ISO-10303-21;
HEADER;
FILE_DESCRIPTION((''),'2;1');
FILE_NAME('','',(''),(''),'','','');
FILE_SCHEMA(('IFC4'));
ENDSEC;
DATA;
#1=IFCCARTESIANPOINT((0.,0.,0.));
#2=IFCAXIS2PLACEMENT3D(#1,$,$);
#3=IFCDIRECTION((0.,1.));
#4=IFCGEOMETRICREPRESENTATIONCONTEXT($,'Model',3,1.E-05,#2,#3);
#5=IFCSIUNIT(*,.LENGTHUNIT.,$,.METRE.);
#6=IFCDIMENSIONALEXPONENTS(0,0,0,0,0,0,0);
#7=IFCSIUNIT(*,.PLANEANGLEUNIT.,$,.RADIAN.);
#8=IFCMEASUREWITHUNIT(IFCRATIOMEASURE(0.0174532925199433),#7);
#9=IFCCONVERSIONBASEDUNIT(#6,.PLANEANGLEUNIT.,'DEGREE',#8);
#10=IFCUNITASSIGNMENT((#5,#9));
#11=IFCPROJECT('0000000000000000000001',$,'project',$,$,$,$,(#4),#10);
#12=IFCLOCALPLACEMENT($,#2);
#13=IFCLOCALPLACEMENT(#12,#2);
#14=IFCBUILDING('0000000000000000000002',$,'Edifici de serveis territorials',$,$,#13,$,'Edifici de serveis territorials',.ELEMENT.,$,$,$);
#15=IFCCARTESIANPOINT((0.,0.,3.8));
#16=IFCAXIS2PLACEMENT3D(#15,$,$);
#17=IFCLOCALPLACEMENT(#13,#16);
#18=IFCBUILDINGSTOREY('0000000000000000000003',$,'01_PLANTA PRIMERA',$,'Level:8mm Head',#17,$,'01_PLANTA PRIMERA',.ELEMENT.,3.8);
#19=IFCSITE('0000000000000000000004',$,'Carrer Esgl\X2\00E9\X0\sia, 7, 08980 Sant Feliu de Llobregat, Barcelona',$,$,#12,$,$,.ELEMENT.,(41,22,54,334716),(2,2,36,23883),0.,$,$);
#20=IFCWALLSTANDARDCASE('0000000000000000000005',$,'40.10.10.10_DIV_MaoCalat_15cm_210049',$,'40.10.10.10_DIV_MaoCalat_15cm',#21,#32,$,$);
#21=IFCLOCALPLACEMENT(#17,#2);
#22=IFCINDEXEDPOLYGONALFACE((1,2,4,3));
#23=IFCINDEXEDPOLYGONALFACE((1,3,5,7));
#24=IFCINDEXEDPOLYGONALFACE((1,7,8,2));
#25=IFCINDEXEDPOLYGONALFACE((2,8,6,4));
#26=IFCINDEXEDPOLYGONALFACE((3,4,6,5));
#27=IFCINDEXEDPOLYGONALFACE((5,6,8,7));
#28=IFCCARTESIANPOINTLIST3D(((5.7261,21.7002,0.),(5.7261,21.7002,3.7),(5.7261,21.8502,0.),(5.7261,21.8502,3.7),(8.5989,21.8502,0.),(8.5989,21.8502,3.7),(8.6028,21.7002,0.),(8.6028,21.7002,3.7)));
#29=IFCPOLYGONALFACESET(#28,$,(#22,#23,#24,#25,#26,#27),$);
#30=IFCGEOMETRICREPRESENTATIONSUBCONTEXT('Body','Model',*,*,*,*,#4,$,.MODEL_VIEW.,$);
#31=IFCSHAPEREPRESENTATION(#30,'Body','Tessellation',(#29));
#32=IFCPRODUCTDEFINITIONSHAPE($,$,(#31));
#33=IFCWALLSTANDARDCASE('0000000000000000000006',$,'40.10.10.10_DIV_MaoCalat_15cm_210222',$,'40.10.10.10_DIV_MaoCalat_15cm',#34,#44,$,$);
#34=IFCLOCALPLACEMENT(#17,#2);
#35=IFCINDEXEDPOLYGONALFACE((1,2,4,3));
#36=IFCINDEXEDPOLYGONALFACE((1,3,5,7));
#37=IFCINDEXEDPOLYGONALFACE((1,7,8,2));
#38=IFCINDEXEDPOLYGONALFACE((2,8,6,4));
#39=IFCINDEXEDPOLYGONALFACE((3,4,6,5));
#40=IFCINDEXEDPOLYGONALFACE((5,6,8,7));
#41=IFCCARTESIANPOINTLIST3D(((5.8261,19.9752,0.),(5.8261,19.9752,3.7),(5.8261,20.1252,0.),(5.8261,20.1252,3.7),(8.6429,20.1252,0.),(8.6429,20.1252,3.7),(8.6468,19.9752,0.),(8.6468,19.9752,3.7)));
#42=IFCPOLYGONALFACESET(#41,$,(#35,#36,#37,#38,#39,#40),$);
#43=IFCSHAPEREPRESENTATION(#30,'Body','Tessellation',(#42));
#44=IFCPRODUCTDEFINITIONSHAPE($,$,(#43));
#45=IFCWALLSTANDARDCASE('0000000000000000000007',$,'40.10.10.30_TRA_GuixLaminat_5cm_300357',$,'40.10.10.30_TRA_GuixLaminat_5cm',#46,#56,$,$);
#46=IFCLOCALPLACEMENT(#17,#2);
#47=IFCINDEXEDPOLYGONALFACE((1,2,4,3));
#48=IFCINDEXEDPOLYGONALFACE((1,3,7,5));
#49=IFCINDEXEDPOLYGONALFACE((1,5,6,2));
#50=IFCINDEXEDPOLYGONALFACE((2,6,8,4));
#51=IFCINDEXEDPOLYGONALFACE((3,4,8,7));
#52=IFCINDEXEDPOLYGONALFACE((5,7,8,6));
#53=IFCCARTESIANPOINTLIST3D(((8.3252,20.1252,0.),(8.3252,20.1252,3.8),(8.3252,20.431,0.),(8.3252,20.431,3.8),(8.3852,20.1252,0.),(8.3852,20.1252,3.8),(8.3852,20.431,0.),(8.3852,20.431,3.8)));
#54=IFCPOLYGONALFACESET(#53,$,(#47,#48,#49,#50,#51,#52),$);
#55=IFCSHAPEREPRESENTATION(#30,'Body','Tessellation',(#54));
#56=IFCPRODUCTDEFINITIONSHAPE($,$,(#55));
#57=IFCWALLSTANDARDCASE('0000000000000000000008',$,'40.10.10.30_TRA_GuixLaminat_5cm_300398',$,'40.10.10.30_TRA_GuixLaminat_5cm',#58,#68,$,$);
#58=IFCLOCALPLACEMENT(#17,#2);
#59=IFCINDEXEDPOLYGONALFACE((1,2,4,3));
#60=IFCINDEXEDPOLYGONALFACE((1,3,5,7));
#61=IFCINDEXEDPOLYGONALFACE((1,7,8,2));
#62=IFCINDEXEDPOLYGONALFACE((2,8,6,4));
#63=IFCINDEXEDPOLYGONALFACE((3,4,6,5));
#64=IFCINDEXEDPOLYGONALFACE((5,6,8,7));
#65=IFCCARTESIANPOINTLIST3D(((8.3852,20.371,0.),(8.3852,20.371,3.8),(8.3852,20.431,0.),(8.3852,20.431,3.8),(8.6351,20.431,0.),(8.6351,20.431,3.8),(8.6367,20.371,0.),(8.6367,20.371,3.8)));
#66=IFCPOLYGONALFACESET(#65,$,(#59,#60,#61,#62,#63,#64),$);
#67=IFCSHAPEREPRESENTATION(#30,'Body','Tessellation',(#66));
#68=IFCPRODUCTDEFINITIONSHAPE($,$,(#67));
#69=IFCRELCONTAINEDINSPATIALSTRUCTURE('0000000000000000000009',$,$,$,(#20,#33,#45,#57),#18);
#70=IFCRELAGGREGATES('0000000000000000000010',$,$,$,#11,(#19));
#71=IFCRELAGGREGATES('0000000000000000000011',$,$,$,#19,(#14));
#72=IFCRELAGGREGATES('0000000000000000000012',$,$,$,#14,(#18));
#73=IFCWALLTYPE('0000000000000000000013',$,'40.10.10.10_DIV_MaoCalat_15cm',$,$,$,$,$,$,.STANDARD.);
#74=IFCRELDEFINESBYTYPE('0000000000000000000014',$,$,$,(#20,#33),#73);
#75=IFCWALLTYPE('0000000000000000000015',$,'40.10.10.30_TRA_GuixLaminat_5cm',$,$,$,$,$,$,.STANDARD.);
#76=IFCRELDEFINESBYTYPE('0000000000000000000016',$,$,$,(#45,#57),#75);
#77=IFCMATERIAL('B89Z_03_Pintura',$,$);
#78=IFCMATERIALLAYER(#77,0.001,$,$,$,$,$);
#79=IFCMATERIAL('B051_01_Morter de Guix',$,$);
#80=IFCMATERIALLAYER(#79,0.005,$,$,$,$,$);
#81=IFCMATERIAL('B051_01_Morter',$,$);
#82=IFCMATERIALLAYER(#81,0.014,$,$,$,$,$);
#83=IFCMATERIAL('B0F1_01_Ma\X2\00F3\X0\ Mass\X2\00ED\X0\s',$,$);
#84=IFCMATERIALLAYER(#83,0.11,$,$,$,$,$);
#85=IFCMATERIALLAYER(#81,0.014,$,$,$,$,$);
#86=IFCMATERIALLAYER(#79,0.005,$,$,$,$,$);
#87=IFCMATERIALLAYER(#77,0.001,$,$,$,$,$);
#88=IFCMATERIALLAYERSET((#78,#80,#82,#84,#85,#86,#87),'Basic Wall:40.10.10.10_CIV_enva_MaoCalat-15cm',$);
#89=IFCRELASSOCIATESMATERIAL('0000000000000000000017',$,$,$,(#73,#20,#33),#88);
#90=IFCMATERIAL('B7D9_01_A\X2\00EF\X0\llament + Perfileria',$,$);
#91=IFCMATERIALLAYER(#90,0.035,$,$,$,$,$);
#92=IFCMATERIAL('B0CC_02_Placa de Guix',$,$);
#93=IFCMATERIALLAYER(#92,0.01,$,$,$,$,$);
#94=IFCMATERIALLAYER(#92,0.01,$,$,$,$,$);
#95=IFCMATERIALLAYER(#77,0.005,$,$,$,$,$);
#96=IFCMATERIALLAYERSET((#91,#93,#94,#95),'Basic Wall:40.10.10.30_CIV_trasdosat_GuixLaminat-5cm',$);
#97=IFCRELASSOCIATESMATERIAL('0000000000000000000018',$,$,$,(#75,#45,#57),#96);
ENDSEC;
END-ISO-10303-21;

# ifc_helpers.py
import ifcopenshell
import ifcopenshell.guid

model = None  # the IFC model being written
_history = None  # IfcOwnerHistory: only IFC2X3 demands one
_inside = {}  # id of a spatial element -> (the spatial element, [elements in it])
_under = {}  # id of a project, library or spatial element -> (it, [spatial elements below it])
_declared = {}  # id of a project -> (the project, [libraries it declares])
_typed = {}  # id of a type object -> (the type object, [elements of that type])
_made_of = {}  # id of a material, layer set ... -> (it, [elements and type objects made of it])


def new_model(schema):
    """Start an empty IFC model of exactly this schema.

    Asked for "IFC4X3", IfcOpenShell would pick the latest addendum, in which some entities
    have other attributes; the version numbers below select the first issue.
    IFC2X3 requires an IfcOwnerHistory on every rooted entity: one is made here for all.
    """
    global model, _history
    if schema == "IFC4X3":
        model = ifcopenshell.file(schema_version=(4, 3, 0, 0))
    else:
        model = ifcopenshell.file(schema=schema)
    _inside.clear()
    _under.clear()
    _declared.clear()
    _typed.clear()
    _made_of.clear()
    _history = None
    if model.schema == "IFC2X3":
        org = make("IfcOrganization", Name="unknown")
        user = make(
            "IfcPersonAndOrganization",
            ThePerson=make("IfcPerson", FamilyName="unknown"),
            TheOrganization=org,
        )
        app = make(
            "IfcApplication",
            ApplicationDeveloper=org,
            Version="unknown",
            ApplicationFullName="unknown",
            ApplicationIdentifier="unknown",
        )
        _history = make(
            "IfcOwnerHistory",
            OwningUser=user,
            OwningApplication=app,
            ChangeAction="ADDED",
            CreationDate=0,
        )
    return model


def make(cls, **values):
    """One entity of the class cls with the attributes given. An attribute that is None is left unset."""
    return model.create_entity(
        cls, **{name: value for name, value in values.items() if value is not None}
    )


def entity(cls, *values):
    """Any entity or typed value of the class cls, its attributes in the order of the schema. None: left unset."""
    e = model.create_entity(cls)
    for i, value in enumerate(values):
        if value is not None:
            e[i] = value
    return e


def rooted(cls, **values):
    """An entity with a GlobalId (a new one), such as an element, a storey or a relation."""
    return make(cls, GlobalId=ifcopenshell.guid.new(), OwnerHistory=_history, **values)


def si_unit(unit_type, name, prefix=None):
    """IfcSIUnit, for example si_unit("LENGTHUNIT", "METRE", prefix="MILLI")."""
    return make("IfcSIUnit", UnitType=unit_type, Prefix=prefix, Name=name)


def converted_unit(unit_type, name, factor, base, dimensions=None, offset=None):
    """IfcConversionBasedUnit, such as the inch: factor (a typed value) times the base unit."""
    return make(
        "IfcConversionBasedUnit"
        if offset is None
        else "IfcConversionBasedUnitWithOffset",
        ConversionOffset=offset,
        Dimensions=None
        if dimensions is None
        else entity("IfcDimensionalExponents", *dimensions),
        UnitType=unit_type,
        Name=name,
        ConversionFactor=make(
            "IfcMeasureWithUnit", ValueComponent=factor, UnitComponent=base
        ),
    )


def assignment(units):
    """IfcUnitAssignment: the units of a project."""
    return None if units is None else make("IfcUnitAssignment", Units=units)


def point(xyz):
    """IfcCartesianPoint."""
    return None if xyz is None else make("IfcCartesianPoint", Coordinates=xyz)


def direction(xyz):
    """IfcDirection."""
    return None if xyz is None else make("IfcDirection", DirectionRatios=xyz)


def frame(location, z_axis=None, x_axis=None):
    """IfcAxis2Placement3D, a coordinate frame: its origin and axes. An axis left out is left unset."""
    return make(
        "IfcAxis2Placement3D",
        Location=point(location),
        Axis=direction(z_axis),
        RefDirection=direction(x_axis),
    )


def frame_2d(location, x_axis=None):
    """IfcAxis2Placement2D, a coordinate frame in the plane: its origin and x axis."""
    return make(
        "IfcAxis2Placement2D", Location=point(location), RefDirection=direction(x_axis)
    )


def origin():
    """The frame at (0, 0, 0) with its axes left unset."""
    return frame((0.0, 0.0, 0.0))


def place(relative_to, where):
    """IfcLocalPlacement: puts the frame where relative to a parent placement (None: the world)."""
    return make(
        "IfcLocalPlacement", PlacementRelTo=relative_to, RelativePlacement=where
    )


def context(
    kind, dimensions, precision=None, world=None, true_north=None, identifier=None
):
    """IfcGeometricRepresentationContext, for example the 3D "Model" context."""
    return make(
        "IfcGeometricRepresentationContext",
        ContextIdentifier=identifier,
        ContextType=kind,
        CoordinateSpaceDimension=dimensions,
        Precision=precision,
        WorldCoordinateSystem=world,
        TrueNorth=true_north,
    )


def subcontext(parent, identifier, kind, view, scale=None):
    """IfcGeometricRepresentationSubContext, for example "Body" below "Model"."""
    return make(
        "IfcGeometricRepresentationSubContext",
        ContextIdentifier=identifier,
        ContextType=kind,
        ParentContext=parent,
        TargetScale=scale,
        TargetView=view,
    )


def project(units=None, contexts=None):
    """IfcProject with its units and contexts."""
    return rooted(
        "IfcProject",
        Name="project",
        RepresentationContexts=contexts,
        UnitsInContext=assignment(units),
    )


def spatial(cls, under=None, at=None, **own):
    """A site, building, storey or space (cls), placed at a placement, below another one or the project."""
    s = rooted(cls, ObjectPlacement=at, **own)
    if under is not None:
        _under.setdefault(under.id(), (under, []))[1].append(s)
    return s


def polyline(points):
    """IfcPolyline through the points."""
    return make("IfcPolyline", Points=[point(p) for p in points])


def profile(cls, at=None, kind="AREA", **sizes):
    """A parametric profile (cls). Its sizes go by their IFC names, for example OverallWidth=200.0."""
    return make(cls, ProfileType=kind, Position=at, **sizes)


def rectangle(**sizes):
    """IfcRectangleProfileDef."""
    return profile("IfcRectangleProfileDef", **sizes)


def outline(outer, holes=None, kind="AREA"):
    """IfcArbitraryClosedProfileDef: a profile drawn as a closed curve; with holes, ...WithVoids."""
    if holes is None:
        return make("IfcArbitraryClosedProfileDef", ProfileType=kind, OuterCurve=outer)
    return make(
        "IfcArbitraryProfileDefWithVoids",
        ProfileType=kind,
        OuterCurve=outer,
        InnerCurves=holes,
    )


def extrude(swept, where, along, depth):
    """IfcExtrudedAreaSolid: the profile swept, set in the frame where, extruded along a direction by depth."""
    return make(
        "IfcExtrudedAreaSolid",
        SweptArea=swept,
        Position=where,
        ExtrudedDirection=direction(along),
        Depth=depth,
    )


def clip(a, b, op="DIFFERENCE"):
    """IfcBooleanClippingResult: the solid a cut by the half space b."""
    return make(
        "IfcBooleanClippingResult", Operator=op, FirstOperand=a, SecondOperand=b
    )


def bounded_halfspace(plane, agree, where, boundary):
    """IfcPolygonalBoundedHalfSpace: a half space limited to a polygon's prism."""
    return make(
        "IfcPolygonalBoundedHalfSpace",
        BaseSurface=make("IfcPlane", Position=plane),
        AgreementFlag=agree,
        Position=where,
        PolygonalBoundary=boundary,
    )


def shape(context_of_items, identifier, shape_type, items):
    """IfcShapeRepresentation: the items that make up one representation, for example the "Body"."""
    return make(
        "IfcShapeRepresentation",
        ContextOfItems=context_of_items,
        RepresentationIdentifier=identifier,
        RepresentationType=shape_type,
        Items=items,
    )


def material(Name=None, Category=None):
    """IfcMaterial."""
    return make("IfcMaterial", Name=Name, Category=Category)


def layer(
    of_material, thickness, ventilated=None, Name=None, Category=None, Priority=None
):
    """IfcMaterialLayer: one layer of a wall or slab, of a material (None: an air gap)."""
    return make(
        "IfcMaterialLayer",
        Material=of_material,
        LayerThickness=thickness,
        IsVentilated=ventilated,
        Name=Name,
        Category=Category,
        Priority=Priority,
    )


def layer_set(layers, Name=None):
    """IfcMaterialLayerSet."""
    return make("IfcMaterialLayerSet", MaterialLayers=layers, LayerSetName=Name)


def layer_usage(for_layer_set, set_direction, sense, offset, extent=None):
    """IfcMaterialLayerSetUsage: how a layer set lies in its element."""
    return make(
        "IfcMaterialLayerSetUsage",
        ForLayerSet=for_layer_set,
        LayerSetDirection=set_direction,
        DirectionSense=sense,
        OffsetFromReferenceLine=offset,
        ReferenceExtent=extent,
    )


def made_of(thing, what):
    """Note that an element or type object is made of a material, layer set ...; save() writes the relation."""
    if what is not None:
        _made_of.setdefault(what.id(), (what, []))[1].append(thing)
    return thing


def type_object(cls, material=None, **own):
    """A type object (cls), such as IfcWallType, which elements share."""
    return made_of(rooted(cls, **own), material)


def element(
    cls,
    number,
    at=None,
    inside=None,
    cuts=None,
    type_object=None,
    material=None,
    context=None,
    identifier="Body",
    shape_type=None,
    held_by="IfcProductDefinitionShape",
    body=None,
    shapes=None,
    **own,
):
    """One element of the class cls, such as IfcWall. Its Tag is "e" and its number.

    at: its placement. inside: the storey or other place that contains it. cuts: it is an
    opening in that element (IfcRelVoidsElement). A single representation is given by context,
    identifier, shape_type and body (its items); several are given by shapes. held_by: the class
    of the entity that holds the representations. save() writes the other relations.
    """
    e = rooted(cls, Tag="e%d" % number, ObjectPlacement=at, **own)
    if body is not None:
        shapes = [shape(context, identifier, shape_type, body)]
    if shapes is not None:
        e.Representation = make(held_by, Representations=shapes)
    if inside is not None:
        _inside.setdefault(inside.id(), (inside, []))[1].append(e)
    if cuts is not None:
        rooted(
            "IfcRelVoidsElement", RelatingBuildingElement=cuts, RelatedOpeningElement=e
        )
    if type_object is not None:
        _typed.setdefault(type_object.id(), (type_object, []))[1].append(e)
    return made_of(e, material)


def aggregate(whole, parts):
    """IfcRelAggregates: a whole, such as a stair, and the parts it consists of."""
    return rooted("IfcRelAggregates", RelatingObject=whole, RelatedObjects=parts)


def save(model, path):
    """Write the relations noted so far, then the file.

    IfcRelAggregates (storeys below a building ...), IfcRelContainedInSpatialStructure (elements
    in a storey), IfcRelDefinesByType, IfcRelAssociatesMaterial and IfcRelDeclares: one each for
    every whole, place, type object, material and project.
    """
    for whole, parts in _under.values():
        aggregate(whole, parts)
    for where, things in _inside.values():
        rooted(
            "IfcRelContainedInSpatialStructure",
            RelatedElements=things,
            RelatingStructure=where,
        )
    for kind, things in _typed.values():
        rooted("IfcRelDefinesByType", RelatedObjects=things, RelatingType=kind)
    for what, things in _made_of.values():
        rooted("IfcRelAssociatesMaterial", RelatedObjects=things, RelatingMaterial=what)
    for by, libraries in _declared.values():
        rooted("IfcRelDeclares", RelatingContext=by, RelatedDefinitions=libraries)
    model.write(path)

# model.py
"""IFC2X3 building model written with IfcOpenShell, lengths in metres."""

from ifc_helpers import new_model, entity, si_unit, converted_unit, direction, frame, frame_2d, origin, place, context, subcontext, project, spatial, polyline, rectangle, outline, extrude, clip, bounded_halfspace, material, layer, layer_set, layer_usage, type_object, element, save


model = new_model("IFC2X3")

# Units and contexts
model_context = context("Model", 3, precision=1e-05, world=origin(), true_north=direction((0.0, 1.0)))
body_context = subcontext(model_context, "Body", "Model", "MODEL_VIEW")
ifc_project = project(units=[si_unit("LENGTHUNIT", "METRE"), converted_unit("PLANEANGLEUNIT", "DEGREE", entity("IfcRatioMeasure", 0.0174532925199433), si_unit("PLANEANGLEUNIT", "RADIAN"), dimensions=[0, 0, 0, 0, 0, 0, 0])], contexts=[model_context])

# Site, building, storey
site_placement = place(None, origin())
site = spatial("IfcSite", under=ifc_project, at=site_placement, Name="Carrer Església, 7, 08980 Sant Feliu de Llobregat, Barcelona", CompositionType="ELEMENT", RefLatitude=(41, 22, 54, 334716), RefLongitude=(2, 2, 36, 23883), RefElevation=0.0)
building_placement = place(site_placement, origin())
building = spatial("IfcBuilding", under=site, at=building_placement, Name="Edifici de serveis territorials", LongName="Edifici de serveis territorials", CompositionType="ELEMENT")
storey_placement = place(building_placement, frame((0.0, 0.0, 3.8)))
storey = spatial("IfcBuildingStorey", under=building, at=storey_placement, Name="01_PLANTA PRIMERA", ObjectType="Level:8mm Head", LongName="01_PLANTA PRIMERA", CompositionType="ELEMENT", Elevation=3.8)

# Shared definitions
ifc_material_1 = material(Name="B0F1_01_Maó Massís")

# Walls
ifc_material_2 = material(Name="B89Z_03_Pintura")
ifc_layer_1 = layer(ifc_material_2, 0.001)
ifc_material_3 = material(Name="B051_01_Morter de Guix")
ifc_layer_2 = layer(ifc_material_3, 0.005)
ifc_material_4 = material(Name="B051_01_Morter")
ifc_layer_3 = layer(ifc_material_4, 0.014)
ifc_layer_4 = layer(ifc_material_1, 0.11)
ifc_layer_5 = layer(ifc_material_4, 0.014)
ifc_layer_6 = layer(ifc_material_3, 0.005)
ifc_layer_7 = layer(ifc_material_2, 0.001)
ifc_layer_set_1 = layer_set([ifc_layer_1, ifc_layer_2, ifc_layer_3, ifc_layer_4, ifc_layer_5, ifc_layer_6, ifc_layer_7], Name="Basic Wall:40.10.10.10_CIV_enva_MaoCalat-15cm")
ifc_layer_usage_1 = layer_usage(ifc_layer_set_1, "AXIS2", "NEGATIVE", 0.075)
wall_type_1 = type_object("IfcWallType", Name="40.10.10.10_DIV_MaoCalat_15cm", PredefinedType="STANDARD", material=ifc_layer_set_1)
wall_1_placement = place(storey_placement, frame((8.6028, 21.7752, 0.0), z_axis=(0.0, 0.0, 1.0), x_axis=(-1.0, 0.0, 0.0)))
element("IfcWallStandardCase", 1, at=wall_1_placement, inside=storey, type_object=wall_type_1, material=ifc_layer_usage_1, Name="40.10.10.10_DIV_MaoCalat_15cm_210049", ObjectType="40.10.10.10_DIV_MaoCalat_15cm", context=body_context, shape_type="Clipping", body=[
    clip(extrude(outline(polyline([(2.8767, -0.075), (2.8767, 0.075), (2.7767, 0.075), (0.0, 0.075), (0.0038, -0.075), (2.8767, -0.075)])), origin(), (0.0, 0.0, 1.0), 3.7), bounded_halfspace(frame((0.0038, -0.075, 3.7), z_axis=(0.0, 0.0, -1.0), x_axis=(0.0, -1.0, 0.0)), True, frame((0.0038, -0.075, 3.7)), polyline([(0.0, 0.0), (2.8728, 0.0), (2.8728, 0.15), (-0.0038, 0.15), (0.0, 0.0)]))),
])
ifc_layer_usage_2 = layer_usage(ifc_layer_set_1, "AXIS2", "NEGATIVE", 0.075)
wall_2_placement = place(storey_placement, frame((5.8261, 20.0502, 0.0)))
element("IfcWallStandardCase", 2, at=wall_2_placement, inside=storey, type_object=wall_type_1, material=ifc_layer_usage_2, Name="40.10.10.10_DIV_MaoCalat_15cm_210222", ObjectType="40.10.10.10_DIV_MaoCalat_15cm", context=body_context, shape_type="Clipping", body=[
    clip(extrude(outline(polyline([(2.8207, -0.075), (2.8168, 0.075), (2.5591, 0.075), (2.4991, 0.075), (0.0, 0.075), (0.0, -0.075), (2.8207, -0.075)])), origin(), (0.0, 0.0, 1.0), 3.7), bounded_halfspace(frame((0.0, -0.075, 3.7), z_axis=(0.0, 0.0, -1.0), x_axis=(0.0, 1.0, 0.0)), True, frame((0.0, -0.075, 3.7)), polyline([(0.0, 0.0), (2.8207, 0.0), (2.8168, 0.15), (0.0, 0.15), (0.0, 0.0)]))),
])
ifc_material_5 = material(Name="B7D9_01_Aïllament + Perfileria")
ifc_layer_8 = layer(ifc_material_5, 0.035)
ifc_material_6 = material(Name="B0CC_02_Placa de Guix")
ifc_layer_9 = layer(ifc_material_6, 0.01)
ifc_layer_10 = layer(ifc_material_6, 0.01)
ifc_layer_11 = layer(ifc_material_2, 0.005)
ifc_layer_set_2 = layer_set([ifc_layer_8, ifc_layer_9, ifc_layer_10, ifc_layer_11], Name="Basic Wall:40.10.10.30_CIV_trasdosat_GuixLaminat-5cm")
ifc_layer_usage_3 = layer_usage(ifc_layer_set_2, "AXIS2", "POSITIVE", -0.03)
wall_type_2 = type_object("IfcWallType", Name="40.10.10.30_TRA_GuixLaminat_5cm", PredefinedType="STANDARD", material=ifc_layer_set_2)
wall_3_placement = place(storey_placement, frame((8.3552, 20.1252, 0.0), z_axis=(0.0, 0.0, 1.0), x_axis=(0.0, 1.0, 0.0)))
element("IfcWallStandardCase", 3, at=wall_3_placement, inside=storey, type_object=wall_type_2, material=ifc_layer_usage_3, Name="40.10.10.30_TRA_GuixLaminat_5cm_300357", ObjectType="40.10.10.30_TRA_GuixLaminat_5cm", context=body_context, shape_type="SweptSolid", body=[
    extrude(rectangle(XDim=0.3058, YDim=0.06, at=frame_2d((0.1529, 0.0), x_axis=(-1.0, 0.0))), origin(), (0.0, 0.0, 1.0), 3.8),
])
ifc_layer_usage_4 = layer_usage(ifc_layer_set_2, "AXIS2", "POSITIVE", -0.03)
wall_4_placement = place(storey_placement, frame((8.3852, 20.401, 0.0)))
element("IfcWallStandardCase", 4, at=wall_4_placement, inside=storey, type_object=wall_type_2, material=ifc_layer_usage_4, Name="40.10.10.30_TRA_GuixLaminat_5cm_300398", ObjectType="40.10.10.30_TRA_GuixLaminat_5cm", context=body_context, shape_type="SweptSolid", body=[
    extrude(outline(polyline([(0.2515, -0.03), (0.25, 0.03), (0.0, 0.03), (0.0, -0.03), (0.2515, -0.03)])), origin(), (0.0, 0.0, 1.0), 3.8),
])

save(model, "model.ifc")
